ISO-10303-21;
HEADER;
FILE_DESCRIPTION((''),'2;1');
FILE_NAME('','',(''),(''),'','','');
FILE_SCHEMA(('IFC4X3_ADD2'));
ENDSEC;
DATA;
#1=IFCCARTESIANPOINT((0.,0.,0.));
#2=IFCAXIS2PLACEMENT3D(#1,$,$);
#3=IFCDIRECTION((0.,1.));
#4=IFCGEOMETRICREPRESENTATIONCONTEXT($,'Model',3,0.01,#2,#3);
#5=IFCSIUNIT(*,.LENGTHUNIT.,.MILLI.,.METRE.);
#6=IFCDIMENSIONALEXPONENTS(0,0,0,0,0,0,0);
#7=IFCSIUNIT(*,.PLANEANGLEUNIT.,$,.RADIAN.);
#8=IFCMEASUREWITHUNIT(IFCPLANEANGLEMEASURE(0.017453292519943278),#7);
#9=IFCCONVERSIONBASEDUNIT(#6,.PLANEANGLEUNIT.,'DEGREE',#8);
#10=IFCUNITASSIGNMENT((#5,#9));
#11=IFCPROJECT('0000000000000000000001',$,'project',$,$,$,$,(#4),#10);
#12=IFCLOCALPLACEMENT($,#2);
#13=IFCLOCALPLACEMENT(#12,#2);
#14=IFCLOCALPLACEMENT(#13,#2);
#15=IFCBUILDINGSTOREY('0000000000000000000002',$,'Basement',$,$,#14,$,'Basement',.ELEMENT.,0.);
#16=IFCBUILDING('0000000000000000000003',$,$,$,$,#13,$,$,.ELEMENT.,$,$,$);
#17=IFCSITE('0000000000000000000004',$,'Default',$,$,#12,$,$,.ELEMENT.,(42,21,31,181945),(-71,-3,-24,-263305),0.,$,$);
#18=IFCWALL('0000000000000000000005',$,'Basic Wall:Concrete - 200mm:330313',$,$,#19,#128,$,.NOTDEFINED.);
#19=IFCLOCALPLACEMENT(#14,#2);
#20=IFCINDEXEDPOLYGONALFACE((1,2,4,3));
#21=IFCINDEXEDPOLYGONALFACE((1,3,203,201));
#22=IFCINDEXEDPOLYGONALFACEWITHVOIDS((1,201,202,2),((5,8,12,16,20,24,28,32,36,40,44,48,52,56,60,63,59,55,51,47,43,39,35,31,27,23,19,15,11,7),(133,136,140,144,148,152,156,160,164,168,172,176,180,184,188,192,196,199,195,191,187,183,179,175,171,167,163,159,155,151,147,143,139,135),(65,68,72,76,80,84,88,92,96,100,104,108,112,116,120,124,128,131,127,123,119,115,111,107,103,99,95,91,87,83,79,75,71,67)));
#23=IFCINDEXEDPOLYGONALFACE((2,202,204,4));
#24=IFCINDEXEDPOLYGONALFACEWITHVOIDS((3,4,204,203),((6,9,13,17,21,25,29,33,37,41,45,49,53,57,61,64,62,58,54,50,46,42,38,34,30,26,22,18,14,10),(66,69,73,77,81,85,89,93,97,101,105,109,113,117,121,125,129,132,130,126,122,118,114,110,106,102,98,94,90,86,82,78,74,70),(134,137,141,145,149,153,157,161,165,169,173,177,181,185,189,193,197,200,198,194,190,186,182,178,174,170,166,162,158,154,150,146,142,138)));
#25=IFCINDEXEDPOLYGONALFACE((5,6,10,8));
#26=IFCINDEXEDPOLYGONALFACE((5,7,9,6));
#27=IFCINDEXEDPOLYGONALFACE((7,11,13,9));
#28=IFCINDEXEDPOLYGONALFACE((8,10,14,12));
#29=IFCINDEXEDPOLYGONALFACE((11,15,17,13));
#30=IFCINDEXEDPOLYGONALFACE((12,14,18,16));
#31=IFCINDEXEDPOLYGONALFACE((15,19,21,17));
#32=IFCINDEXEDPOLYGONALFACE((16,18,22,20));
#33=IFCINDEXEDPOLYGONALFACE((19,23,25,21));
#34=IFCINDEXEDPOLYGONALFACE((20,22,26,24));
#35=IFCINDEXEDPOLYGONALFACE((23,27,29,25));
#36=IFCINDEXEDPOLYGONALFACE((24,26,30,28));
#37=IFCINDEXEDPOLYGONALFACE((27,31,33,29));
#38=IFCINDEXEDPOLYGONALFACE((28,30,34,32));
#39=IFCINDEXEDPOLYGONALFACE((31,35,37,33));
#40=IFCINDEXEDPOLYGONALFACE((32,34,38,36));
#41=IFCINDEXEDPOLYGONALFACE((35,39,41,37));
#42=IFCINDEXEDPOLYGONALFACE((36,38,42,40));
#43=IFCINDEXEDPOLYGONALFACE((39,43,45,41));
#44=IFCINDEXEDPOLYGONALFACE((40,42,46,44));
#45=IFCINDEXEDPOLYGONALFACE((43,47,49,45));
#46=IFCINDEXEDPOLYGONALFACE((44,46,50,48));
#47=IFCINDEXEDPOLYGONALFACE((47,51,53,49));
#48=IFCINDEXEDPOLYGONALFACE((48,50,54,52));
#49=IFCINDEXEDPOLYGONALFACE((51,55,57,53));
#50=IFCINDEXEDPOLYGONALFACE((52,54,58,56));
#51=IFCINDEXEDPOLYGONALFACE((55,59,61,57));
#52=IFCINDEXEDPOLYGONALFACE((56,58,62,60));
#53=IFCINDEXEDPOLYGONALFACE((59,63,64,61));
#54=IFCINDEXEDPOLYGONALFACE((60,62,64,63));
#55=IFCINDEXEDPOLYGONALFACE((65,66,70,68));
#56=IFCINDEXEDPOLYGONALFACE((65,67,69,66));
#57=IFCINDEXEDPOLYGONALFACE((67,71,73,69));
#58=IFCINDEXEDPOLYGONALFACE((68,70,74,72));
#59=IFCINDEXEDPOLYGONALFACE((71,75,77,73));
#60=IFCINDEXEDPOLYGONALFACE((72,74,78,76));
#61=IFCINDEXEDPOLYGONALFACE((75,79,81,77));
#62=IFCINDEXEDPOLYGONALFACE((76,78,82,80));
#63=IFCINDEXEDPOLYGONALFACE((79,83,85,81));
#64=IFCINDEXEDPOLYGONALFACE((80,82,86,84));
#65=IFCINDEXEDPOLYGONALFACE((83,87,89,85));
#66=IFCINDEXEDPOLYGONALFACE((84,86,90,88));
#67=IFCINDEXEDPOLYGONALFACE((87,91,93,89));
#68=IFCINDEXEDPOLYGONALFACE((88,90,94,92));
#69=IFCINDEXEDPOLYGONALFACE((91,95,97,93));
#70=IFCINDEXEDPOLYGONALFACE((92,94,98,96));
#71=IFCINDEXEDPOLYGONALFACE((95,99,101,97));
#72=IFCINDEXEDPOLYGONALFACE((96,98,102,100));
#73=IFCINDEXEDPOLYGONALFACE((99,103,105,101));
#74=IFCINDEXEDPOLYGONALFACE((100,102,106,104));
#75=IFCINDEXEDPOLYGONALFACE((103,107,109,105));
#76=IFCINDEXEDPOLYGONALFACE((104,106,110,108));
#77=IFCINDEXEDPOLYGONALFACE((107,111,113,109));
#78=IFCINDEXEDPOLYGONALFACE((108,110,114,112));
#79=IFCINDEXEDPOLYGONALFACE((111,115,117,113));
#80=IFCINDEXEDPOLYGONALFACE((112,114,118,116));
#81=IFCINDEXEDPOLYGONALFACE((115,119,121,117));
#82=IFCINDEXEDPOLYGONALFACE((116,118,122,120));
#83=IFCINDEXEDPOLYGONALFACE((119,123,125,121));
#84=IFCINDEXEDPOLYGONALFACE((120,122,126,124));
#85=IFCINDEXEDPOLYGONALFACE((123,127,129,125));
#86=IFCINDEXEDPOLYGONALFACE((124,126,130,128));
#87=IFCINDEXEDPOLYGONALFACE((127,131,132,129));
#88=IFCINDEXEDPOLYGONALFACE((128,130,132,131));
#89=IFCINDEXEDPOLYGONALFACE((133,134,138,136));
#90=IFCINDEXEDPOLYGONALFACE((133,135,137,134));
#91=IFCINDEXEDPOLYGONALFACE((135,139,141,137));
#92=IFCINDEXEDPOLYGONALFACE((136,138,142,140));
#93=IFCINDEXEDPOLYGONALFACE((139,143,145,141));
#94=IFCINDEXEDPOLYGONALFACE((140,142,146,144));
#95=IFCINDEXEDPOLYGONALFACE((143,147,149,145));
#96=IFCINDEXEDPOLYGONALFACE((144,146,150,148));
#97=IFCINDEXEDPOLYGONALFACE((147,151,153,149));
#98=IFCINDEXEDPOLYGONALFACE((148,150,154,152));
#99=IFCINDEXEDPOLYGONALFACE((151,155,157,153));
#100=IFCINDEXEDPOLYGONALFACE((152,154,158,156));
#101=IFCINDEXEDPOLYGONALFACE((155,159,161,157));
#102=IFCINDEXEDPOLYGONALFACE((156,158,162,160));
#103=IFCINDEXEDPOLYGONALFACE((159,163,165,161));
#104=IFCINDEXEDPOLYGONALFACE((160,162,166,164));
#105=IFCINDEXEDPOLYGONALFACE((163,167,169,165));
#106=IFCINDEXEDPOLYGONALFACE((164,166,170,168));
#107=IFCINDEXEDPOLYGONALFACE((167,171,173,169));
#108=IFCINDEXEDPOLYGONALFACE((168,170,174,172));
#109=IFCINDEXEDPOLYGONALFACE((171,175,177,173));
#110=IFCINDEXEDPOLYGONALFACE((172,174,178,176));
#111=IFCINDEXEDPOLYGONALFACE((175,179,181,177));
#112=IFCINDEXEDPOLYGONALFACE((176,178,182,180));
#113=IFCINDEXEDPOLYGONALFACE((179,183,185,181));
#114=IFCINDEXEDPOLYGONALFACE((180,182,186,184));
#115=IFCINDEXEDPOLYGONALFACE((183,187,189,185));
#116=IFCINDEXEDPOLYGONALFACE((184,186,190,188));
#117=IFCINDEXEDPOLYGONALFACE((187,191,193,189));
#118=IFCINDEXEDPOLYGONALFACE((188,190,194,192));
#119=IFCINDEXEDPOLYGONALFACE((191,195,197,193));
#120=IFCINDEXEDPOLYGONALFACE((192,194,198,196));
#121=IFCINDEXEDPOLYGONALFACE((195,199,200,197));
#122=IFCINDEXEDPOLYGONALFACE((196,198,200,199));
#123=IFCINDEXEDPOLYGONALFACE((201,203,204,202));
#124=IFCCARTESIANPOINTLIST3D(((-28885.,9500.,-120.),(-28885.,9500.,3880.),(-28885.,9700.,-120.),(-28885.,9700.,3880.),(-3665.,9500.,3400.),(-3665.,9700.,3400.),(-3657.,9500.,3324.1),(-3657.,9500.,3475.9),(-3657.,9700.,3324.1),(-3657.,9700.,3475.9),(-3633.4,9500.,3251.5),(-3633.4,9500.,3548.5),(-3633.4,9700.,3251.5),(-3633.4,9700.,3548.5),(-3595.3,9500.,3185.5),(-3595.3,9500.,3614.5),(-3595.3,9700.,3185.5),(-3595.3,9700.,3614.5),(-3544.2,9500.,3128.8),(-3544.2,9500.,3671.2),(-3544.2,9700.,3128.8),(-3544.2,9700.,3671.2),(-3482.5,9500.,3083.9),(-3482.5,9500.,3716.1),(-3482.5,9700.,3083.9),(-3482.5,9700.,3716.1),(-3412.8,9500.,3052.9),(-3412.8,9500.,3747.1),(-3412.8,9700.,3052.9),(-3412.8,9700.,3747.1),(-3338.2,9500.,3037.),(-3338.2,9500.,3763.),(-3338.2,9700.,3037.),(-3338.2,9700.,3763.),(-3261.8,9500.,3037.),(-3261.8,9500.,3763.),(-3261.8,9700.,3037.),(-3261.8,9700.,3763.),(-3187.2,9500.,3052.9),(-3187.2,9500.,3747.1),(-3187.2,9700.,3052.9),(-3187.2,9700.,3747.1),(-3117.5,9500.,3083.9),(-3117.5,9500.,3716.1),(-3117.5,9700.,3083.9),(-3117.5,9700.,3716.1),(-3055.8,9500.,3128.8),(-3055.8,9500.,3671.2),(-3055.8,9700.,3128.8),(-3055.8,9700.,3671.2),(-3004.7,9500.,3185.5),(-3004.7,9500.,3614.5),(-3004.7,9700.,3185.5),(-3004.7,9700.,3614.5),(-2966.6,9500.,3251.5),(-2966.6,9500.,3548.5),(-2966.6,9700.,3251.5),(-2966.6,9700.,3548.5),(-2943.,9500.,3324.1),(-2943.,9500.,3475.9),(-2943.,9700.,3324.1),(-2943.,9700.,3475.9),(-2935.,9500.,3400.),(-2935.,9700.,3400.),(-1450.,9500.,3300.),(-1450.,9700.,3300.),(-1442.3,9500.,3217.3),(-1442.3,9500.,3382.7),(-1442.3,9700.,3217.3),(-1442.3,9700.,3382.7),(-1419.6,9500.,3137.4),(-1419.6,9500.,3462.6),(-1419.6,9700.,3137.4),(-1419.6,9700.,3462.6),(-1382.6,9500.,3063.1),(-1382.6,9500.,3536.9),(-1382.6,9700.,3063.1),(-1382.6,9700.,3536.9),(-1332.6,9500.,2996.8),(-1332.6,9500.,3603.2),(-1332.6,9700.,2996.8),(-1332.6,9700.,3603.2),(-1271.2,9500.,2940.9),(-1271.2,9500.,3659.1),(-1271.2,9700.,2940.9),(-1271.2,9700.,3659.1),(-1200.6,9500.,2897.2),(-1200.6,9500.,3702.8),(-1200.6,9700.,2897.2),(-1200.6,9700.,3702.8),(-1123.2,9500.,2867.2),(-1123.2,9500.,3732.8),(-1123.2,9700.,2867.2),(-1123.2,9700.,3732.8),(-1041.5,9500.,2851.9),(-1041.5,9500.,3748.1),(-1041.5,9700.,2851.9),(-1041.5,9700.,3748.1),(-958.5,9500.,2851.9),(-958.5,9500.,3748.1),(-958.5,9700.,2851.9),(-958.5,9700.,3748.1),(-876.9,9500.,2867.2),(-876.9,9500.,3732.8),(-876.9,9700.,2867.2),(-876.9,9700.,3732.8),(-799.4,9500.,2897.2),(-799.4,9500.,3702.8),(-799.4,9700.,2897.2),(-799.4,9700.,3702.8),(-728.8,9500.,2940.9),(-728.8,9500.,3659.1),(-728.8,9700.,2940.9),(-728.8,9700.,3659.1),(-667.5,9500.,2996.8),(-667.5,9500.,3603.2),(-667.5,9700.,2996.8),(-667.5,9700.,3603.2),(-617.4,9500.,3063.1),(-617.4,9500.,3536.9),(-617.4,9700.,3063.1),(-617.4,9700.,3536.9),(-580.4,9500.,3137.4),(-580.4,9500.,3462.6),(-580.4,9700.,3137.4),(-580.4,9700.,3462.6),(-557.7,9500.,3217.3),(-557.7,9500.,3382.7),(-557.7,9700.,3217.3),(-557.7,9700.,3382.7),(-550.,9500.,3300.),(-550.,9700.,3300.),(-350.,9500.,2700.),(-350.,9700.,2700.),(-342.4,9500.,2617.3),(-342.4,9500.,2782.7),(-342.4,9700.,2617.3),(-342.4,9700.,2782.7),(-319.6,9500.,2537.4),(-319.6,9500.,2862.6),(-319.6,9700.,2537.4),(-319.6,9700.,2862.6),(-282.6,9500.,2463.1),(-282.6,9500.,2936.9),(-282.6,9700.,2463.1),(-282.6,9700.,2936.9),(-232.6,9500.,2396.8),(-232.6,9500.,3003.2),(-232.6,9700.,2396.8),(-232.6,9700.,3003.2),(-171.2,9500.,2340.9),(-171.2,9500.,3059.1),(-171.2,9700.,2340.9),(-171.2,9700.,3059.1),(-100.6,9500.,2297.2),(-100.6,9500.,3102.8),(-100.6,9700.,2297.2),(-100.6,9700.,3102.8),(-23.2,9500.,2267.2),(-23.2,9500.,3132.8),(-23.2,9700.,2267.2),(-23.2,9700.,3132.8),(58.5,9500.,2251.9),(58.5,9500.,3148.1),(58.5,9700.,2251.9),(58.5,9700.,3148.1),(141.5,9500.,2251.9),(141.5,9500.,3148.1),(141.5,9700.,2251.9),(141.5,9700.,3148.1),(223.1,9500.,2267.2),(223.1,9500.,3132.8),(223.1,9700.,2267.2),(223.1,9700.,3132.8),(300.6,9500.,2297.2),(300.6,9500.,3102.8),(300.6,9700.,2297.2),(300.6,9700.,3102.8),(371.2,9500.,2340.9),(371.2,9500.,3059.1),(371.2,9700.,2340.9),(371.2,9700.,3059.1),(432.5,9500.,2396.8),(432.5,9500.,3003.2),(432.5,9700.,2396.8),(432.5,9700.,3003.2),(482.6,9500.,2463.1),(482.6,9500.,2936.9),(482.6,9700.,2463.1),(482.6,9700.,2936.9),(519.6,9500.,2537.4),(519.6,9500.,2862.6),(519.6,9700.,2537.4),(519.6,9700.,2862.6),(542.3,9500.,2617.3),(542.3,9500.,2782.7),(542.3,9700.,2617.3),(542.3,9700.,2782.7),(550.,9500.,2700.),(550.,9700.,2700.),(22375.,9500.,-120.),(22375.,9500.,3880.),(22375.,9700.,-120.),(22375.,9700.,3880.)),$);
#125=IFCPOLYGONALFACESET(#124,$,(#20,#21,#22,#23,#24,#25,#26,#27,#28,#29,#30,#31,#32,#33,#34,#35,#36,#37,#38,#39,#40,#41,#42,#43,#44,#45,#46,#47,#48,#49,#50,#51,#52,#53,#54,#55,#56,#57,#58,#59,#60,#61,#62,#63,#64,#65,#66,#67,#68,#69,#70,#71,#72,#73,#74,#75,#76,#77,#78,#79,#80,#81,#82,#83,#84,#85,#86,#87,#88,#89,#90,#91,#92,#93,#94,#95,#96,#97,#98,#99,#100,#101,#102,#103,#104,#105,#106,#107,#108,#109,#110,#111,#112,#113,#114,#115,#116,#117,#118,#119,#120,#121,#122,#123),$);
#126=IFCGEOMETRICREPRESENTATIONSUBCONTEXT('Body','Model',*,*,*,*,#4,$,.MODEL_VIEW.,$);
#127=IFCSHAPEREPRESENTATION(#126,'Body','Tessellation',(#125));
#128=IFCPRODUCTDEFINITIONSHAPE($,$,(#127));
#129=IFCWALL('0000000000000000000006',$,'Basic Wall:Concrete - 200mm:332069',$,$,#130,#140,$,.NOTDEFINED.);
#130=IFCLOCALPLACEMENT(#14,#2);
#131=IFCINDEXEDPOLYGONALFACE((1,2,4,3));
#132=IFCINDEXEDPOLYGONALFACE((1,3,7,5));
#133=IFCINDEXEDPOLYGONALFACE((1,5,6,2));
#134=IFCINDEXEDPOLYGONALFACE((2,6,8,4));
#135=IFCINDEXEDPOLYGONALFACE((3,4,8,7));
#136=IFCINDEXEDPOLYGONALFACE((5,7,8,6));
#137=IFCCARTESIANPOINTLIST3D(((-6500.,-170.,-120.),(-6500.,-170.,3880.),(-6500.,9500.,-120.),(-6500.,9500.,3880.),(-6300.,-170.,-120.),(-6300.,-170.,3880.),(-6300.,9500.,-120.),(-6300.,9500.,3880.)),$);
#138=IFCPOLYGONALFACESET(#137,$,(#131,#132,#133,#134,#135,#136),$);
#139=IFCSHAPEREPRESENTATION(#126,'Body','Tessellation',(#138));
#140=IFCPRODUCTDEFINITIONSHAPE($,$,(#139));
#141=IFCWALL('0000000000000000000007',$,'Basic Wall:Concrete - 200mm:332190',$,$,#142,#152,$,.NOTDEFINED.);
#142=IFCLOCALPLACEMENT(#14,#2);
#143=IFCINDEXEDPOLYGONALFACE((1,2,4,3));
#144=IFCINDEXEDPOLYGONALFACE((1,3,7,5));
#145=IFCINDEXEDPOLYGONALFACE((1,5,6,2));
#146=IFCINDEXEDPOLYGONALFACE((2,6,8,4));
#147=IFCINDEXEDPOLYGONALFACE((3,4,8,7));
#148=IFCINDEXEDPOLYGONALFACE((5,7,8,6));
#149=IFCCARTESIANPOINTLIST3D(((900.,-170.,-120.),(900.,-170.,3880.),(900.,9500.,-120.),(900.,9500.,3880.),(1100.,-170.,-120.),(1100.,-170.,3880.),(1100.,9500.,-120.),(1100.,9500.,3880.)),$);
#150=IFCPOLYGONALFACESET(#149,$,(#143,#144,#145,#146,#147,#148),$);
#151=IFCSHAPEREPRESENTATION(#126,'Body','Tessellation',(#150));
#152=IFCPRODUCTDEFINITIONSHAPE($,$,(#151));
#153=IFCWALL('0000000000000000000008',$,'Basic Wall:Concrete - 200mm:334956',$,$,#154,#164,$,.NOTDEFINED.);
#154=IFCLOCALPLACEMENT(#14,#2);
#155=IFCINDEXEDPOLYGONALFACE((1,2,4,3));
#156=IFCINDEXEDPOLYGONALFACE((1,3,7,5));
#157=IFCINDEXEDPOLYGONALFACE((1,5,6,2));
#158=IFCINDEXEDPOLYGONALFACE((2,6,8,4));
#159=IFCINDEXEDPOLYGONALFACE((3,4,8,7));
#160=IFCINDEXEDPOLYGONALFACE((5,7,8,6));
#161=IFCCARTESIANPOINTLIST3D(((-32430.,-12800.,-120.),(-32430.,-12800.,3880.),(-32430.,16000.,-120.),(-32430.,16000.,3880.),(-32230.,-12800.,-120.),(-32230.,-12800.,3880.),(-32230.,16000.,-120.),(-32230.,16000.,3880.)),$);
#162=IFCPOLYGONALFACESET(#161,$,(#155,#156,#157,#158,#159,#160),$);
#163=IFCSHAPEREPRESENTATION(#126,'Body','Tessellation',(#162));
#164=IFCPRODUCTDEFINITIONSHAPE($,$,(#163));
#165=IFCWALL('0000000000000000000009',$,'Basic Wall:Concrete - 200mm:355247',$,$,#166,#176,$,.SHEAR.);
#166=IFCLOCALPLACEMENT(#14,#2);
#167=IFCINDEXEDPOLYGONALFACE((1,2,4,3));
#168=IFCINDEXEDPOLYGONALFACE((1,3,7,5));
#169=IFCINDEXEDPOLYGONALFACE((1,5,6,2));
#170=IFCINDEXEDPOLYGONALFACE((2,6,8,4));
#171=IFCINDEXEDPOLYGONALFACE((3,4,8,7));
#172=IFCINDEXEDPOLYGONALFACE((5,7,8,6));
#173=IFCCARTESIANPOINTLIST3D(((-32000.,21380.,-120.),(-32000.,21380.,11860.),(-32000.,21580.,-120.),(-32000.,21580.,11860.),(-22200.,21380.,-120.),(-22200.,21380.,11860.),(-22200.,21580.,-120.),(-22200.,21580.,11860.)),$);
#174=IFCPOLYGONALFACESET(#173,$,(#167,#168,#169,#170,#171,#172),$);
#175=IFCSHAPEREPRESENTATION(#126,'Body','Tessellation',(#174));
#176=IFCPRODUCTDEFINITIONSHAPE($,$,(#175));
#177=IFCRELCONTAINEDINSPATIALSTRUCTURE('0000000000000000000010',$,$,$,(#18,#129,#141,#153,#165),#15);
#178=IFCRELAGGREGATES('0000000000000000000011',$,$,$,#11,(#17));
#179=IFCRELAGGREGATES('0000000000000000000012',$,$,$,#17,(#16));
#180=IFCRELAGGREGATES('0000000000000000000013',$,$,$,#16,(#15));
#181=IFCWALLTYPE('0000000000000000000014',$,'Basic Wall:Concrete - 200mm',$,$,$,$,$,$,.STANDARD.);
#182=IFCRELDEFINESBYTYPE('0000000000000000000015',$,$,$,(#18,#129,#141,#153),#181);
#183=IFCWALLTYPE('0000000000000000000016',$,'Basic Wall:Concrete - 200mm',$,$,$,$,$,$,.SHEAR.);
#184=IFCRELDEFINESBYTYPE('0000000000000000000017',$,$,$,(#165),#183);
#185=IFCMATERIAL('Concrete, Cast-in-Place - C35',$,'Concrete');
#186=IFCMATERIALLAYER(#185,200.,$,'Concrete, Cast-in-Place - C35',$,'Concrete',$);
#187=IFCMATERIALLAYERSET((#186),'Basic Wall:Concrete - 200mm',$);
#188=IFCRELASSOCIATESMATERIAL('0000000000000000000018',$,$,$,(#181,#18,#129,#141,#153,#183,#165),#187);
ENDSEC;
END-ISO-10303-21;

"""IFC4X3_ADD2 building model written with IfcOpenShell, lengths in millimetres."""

from ifc_helpers import new_model, entity, si_unit, converted_unit, direction, frame, frame_2d, origin, place, context, subcontext, project, spatial, rectangle, circle, extrude, material, layer, layer_set, type_object, element, save


model = new_model("IFC4X3_ADD2")

# Units and contexts
model_context = context("Model", 3, precision=0.01, world=origin(), true_north=direction((0.0, 1.0)))
body_context = subcontext(model_context, "Body", "Model", "MODEL_VIEW")
ifc_project = project(units=[si_unit("LENGTHUNIT", "METRE", prefix="MILLI"), converted_unit("PLANEANGLEUNIT", "DEGREE", entity("IfcPlaneAngleMeasure", 0.017453292519943278), si_unit("PLANEANGLEUNIT", "RADIAN"), dimensions=[0, 0, 0, 0, 0, 0, 0])], contexts=[model_context])

# Site, building, storey
site_placement = place(None, origin())
site = spatial("IfcSite", under=ifc_project, at=site_placement, Name="Default", CompositionType="ELEMENT", RefLatitude=(42, 21, 31, 181945), RefLongitude=(-71, -3, -24, -263305), RefElevation=0.0)
building_placement = place(site_placement, origin())
building = spatial("IfcBuilding", under=site, at=building_placement, CompositionType="ELEMENT")
storey_placement = place(building_placement, origin())
storey = spatial("IfcBuildingStorey", under=building, at=storey_placement, Name="Basement", LongName="Basement", CompositionType="ELEMENT", Elevation=0.0)

# Shared definitions
ifc_material = material(Name="Concrete, Cast-in-Place - C35", Category="Concrete")

# Wall, openings
ifc_layer_1 = layer(ifc_material, 200.0, Name="Concrete, Cast-in-Place - C35", Category="Concrete")
ifc_layer_set_1 = layer_set([ifc_layer_1], Name="Basic Wall:Concrete - 200mm")
wall_type_1 = type_object("IfcWallType", Name="Basic Wall:Concrete - 200mm", PredefinedType="STANDARD", material=ifc_layer_set_1)
wall_1_placement = place(storey_placement, frame((-28885.0, 9600.0, -120.0)))
wall_1 = element("IfcWall", 1, at=wall_1_placement, inside=storey, type_object=wall_type_1, material=ifc_layer_set_1, Name="Basic Wall:Concrete - 200mm:330313", PredefinedType="NOTDEFINED", context=body_context, shape_type="SweptSolid", body=[
    extrude(rectangle(XDim=51260.0, YDim=200.0, at=frame_2d((25630.0, 0.0), x_axis=(-1.0, 0.0))), origin(), (0.0, 0.0, 1.0), 4000.0),
])
opening_1_placement = place(wall_1_placement, frame((28885.0, -9600.0, 3270.0)))
element("IfcOpeningElement", 2, at=opening_1_placement, cuts=wall_1, PredefinedType="OPENING", context=body_context, shape_type="SweptSolid", body=[
    extrude(circle(Radius=250.0, at=frame_2d((0.0, 0.0), x_axis=(1.0, 0.0))), frame((-3300.0, 9350.0, 250.0), z_axis=(0.0, 1.0, 0.0), x_axis=(-1.0, 0.0, 0.0)), (0.0, 0.0, 1.0), 500.0),
])
opening_2_placement = place(wall_1_placement, frame((28885.0, -9600.0, 3155.0)))
element("IfcOpeningElement", 3, at=opening_2_placement, cuts=wall_1, PredefinedType="OPENING", context=body_context, shape_type="SweptSolid", body=[
    extrude(circle(Radius=365.0, at=frame_2d((0.0, 0.0), x_axis=(1.0, 0.0))), frame((-3300.0, 9350.0, 365.0), z_axis=(0.0, 1.0, 0.0), x_axis=(-1.0, 0.0, 0.0)), (0.0, 0.0, 1.0), 500.0),
])
opening_3_placement = place(wall_1_placement, frame((28885.0, -9600.0, 2970.0)))
element("IfcOpeningElement", 4, at=opening_3_placement, cuts=wall_1, PredefinedType="OPENING", context=body_context, shape_type="SweptSolid", body=[
    extrude(circle(Radius=450.0, at=frame_2d((0.0, 0.0), x_axis=(1.0, 0.0))), frame((-1000.0, 9350.0, 450.0), z_axis=(0.0, 1.0, 0.0), x_axis=(-1.0, 0.0, 0.0)), (0.0, 0.0, 1.0), 500.0),
])
opening_4_placement = place(wall_1_placement, frame((28885.0, -9600.0, 2370.0)))
element("IfcOpeningElement", 5, at=opening_4_placement, cuts=wall_1, PredefinedType="OPENING", context=body_context, shape_type="SweptSolid", body=[
    extrude(circle(Radius=450.0, at=frame_2d((0.0, 0.0), x_axis=(1.0, 0.0))), frame((100.0, 9350.0, 450.0), z_axis=(0.0, 1.0, 0.0), x_axis=(-1.0, 0.0, 0.0)), (0.0, 0.0, 1.0), 500.0),
])

# Walls
wall_2_placement = place(storey_placement, frame((-6400.0, 9500.0, -120.0), z_axis=(0.0, 0.0, 1.0), x_axis=(0.0, -1.0, 0.0)))
element("IfcWall", 6, at=wall_2_placement, inside=storey, type_object=wall_type_1, material=ifc_layer_set_1, Name="Basic Wall:Concrete - 200mm:332069", PredefinedType="NOTDEFINED", context=body_context, shape_type="SweptSolid", body=[
    extrude(rectangle(XDim=9670.0, YDim=200.0, at=frame_2d((4835.0, 0.0), x_axis=(-1.0, 0.0))), origin(), (0.0, 0.0, 1.0), 4000.0),
])
wall_3_placement = place(storey_placement, frame((1000.0, 9500.0, -120.0), z_axis=(0.0, 0.0, 1.0), x_axis=(0.0, -1.0, 0.0)))
element("IfcWall", 7, at=wall_3_placement, inside=storey, type_object=wall_type_1, material=ifc_layer_set_1, Name="Basic Wall:Concrete - 200mm:332190", PredefinedType="NOTDEFINED", context=body_context, shape_type="SweptSolid", body=[
    extrude(rectangle(XDim=9670.0, YDim=200.0, at=frame_2d((4835.0, 0.0), x_axis=(-1.0, 0.0))), origin(), (0.0, 0.0, 1.0), 4000.0),
])
wall_4_placement = place(storey_placement, frame((-32330.0, 16000.0, -120.0), z_axis=(0.0, 0.0, 1.0), x_axis=(0.0, -1.0, 0.0)))
element("IfcWall", 8, at=wall_4_placement, inside=storey, type_object=wall_type_1, material=ifc_layer_set_1, Name="Basic Wall:Concrete - 200mm:334956", PredefinedType="NOTDEFINED", context=body_context, shape_type="SweptSolid", body=[
    extrude(rectangle(XDim=28800.0, YDim=200.0, at=frame_2d((14400.0, 0.0), x_axis=(-1.0, 0.0))), origin(), (0.0, 0.0, 1.0), 4000.0),
])
wall_type_2 = type_object("IfcWallType", Name="Basic Wall:Concrete - 200mm", PredefinedType="SHEAR", material=ifc_layer_set_1)
wall_5_placement = place(storey_placement, frame((-32000.0, 21480.0, -120.0)))
element("IfcWall", 9, at=wall_5_placement, inside=storey, type_object=wall_type_2, material=ifc_layer_set_1, Name="Basic Wall:Concrete - 200mm:355247", PredefinedType="SHEAR", context=body_context, shape_type="SweptSolid", body=[
    extrude(rectangle(XDim=9800.0, YDim=200.0, at=frame_2d((4900.0, 0.0), x_axis=(-1.0, 0.0))), origin(), (0.0, 0.0, 1.0), 11980.0),
])

save(model, "model.ifc")
